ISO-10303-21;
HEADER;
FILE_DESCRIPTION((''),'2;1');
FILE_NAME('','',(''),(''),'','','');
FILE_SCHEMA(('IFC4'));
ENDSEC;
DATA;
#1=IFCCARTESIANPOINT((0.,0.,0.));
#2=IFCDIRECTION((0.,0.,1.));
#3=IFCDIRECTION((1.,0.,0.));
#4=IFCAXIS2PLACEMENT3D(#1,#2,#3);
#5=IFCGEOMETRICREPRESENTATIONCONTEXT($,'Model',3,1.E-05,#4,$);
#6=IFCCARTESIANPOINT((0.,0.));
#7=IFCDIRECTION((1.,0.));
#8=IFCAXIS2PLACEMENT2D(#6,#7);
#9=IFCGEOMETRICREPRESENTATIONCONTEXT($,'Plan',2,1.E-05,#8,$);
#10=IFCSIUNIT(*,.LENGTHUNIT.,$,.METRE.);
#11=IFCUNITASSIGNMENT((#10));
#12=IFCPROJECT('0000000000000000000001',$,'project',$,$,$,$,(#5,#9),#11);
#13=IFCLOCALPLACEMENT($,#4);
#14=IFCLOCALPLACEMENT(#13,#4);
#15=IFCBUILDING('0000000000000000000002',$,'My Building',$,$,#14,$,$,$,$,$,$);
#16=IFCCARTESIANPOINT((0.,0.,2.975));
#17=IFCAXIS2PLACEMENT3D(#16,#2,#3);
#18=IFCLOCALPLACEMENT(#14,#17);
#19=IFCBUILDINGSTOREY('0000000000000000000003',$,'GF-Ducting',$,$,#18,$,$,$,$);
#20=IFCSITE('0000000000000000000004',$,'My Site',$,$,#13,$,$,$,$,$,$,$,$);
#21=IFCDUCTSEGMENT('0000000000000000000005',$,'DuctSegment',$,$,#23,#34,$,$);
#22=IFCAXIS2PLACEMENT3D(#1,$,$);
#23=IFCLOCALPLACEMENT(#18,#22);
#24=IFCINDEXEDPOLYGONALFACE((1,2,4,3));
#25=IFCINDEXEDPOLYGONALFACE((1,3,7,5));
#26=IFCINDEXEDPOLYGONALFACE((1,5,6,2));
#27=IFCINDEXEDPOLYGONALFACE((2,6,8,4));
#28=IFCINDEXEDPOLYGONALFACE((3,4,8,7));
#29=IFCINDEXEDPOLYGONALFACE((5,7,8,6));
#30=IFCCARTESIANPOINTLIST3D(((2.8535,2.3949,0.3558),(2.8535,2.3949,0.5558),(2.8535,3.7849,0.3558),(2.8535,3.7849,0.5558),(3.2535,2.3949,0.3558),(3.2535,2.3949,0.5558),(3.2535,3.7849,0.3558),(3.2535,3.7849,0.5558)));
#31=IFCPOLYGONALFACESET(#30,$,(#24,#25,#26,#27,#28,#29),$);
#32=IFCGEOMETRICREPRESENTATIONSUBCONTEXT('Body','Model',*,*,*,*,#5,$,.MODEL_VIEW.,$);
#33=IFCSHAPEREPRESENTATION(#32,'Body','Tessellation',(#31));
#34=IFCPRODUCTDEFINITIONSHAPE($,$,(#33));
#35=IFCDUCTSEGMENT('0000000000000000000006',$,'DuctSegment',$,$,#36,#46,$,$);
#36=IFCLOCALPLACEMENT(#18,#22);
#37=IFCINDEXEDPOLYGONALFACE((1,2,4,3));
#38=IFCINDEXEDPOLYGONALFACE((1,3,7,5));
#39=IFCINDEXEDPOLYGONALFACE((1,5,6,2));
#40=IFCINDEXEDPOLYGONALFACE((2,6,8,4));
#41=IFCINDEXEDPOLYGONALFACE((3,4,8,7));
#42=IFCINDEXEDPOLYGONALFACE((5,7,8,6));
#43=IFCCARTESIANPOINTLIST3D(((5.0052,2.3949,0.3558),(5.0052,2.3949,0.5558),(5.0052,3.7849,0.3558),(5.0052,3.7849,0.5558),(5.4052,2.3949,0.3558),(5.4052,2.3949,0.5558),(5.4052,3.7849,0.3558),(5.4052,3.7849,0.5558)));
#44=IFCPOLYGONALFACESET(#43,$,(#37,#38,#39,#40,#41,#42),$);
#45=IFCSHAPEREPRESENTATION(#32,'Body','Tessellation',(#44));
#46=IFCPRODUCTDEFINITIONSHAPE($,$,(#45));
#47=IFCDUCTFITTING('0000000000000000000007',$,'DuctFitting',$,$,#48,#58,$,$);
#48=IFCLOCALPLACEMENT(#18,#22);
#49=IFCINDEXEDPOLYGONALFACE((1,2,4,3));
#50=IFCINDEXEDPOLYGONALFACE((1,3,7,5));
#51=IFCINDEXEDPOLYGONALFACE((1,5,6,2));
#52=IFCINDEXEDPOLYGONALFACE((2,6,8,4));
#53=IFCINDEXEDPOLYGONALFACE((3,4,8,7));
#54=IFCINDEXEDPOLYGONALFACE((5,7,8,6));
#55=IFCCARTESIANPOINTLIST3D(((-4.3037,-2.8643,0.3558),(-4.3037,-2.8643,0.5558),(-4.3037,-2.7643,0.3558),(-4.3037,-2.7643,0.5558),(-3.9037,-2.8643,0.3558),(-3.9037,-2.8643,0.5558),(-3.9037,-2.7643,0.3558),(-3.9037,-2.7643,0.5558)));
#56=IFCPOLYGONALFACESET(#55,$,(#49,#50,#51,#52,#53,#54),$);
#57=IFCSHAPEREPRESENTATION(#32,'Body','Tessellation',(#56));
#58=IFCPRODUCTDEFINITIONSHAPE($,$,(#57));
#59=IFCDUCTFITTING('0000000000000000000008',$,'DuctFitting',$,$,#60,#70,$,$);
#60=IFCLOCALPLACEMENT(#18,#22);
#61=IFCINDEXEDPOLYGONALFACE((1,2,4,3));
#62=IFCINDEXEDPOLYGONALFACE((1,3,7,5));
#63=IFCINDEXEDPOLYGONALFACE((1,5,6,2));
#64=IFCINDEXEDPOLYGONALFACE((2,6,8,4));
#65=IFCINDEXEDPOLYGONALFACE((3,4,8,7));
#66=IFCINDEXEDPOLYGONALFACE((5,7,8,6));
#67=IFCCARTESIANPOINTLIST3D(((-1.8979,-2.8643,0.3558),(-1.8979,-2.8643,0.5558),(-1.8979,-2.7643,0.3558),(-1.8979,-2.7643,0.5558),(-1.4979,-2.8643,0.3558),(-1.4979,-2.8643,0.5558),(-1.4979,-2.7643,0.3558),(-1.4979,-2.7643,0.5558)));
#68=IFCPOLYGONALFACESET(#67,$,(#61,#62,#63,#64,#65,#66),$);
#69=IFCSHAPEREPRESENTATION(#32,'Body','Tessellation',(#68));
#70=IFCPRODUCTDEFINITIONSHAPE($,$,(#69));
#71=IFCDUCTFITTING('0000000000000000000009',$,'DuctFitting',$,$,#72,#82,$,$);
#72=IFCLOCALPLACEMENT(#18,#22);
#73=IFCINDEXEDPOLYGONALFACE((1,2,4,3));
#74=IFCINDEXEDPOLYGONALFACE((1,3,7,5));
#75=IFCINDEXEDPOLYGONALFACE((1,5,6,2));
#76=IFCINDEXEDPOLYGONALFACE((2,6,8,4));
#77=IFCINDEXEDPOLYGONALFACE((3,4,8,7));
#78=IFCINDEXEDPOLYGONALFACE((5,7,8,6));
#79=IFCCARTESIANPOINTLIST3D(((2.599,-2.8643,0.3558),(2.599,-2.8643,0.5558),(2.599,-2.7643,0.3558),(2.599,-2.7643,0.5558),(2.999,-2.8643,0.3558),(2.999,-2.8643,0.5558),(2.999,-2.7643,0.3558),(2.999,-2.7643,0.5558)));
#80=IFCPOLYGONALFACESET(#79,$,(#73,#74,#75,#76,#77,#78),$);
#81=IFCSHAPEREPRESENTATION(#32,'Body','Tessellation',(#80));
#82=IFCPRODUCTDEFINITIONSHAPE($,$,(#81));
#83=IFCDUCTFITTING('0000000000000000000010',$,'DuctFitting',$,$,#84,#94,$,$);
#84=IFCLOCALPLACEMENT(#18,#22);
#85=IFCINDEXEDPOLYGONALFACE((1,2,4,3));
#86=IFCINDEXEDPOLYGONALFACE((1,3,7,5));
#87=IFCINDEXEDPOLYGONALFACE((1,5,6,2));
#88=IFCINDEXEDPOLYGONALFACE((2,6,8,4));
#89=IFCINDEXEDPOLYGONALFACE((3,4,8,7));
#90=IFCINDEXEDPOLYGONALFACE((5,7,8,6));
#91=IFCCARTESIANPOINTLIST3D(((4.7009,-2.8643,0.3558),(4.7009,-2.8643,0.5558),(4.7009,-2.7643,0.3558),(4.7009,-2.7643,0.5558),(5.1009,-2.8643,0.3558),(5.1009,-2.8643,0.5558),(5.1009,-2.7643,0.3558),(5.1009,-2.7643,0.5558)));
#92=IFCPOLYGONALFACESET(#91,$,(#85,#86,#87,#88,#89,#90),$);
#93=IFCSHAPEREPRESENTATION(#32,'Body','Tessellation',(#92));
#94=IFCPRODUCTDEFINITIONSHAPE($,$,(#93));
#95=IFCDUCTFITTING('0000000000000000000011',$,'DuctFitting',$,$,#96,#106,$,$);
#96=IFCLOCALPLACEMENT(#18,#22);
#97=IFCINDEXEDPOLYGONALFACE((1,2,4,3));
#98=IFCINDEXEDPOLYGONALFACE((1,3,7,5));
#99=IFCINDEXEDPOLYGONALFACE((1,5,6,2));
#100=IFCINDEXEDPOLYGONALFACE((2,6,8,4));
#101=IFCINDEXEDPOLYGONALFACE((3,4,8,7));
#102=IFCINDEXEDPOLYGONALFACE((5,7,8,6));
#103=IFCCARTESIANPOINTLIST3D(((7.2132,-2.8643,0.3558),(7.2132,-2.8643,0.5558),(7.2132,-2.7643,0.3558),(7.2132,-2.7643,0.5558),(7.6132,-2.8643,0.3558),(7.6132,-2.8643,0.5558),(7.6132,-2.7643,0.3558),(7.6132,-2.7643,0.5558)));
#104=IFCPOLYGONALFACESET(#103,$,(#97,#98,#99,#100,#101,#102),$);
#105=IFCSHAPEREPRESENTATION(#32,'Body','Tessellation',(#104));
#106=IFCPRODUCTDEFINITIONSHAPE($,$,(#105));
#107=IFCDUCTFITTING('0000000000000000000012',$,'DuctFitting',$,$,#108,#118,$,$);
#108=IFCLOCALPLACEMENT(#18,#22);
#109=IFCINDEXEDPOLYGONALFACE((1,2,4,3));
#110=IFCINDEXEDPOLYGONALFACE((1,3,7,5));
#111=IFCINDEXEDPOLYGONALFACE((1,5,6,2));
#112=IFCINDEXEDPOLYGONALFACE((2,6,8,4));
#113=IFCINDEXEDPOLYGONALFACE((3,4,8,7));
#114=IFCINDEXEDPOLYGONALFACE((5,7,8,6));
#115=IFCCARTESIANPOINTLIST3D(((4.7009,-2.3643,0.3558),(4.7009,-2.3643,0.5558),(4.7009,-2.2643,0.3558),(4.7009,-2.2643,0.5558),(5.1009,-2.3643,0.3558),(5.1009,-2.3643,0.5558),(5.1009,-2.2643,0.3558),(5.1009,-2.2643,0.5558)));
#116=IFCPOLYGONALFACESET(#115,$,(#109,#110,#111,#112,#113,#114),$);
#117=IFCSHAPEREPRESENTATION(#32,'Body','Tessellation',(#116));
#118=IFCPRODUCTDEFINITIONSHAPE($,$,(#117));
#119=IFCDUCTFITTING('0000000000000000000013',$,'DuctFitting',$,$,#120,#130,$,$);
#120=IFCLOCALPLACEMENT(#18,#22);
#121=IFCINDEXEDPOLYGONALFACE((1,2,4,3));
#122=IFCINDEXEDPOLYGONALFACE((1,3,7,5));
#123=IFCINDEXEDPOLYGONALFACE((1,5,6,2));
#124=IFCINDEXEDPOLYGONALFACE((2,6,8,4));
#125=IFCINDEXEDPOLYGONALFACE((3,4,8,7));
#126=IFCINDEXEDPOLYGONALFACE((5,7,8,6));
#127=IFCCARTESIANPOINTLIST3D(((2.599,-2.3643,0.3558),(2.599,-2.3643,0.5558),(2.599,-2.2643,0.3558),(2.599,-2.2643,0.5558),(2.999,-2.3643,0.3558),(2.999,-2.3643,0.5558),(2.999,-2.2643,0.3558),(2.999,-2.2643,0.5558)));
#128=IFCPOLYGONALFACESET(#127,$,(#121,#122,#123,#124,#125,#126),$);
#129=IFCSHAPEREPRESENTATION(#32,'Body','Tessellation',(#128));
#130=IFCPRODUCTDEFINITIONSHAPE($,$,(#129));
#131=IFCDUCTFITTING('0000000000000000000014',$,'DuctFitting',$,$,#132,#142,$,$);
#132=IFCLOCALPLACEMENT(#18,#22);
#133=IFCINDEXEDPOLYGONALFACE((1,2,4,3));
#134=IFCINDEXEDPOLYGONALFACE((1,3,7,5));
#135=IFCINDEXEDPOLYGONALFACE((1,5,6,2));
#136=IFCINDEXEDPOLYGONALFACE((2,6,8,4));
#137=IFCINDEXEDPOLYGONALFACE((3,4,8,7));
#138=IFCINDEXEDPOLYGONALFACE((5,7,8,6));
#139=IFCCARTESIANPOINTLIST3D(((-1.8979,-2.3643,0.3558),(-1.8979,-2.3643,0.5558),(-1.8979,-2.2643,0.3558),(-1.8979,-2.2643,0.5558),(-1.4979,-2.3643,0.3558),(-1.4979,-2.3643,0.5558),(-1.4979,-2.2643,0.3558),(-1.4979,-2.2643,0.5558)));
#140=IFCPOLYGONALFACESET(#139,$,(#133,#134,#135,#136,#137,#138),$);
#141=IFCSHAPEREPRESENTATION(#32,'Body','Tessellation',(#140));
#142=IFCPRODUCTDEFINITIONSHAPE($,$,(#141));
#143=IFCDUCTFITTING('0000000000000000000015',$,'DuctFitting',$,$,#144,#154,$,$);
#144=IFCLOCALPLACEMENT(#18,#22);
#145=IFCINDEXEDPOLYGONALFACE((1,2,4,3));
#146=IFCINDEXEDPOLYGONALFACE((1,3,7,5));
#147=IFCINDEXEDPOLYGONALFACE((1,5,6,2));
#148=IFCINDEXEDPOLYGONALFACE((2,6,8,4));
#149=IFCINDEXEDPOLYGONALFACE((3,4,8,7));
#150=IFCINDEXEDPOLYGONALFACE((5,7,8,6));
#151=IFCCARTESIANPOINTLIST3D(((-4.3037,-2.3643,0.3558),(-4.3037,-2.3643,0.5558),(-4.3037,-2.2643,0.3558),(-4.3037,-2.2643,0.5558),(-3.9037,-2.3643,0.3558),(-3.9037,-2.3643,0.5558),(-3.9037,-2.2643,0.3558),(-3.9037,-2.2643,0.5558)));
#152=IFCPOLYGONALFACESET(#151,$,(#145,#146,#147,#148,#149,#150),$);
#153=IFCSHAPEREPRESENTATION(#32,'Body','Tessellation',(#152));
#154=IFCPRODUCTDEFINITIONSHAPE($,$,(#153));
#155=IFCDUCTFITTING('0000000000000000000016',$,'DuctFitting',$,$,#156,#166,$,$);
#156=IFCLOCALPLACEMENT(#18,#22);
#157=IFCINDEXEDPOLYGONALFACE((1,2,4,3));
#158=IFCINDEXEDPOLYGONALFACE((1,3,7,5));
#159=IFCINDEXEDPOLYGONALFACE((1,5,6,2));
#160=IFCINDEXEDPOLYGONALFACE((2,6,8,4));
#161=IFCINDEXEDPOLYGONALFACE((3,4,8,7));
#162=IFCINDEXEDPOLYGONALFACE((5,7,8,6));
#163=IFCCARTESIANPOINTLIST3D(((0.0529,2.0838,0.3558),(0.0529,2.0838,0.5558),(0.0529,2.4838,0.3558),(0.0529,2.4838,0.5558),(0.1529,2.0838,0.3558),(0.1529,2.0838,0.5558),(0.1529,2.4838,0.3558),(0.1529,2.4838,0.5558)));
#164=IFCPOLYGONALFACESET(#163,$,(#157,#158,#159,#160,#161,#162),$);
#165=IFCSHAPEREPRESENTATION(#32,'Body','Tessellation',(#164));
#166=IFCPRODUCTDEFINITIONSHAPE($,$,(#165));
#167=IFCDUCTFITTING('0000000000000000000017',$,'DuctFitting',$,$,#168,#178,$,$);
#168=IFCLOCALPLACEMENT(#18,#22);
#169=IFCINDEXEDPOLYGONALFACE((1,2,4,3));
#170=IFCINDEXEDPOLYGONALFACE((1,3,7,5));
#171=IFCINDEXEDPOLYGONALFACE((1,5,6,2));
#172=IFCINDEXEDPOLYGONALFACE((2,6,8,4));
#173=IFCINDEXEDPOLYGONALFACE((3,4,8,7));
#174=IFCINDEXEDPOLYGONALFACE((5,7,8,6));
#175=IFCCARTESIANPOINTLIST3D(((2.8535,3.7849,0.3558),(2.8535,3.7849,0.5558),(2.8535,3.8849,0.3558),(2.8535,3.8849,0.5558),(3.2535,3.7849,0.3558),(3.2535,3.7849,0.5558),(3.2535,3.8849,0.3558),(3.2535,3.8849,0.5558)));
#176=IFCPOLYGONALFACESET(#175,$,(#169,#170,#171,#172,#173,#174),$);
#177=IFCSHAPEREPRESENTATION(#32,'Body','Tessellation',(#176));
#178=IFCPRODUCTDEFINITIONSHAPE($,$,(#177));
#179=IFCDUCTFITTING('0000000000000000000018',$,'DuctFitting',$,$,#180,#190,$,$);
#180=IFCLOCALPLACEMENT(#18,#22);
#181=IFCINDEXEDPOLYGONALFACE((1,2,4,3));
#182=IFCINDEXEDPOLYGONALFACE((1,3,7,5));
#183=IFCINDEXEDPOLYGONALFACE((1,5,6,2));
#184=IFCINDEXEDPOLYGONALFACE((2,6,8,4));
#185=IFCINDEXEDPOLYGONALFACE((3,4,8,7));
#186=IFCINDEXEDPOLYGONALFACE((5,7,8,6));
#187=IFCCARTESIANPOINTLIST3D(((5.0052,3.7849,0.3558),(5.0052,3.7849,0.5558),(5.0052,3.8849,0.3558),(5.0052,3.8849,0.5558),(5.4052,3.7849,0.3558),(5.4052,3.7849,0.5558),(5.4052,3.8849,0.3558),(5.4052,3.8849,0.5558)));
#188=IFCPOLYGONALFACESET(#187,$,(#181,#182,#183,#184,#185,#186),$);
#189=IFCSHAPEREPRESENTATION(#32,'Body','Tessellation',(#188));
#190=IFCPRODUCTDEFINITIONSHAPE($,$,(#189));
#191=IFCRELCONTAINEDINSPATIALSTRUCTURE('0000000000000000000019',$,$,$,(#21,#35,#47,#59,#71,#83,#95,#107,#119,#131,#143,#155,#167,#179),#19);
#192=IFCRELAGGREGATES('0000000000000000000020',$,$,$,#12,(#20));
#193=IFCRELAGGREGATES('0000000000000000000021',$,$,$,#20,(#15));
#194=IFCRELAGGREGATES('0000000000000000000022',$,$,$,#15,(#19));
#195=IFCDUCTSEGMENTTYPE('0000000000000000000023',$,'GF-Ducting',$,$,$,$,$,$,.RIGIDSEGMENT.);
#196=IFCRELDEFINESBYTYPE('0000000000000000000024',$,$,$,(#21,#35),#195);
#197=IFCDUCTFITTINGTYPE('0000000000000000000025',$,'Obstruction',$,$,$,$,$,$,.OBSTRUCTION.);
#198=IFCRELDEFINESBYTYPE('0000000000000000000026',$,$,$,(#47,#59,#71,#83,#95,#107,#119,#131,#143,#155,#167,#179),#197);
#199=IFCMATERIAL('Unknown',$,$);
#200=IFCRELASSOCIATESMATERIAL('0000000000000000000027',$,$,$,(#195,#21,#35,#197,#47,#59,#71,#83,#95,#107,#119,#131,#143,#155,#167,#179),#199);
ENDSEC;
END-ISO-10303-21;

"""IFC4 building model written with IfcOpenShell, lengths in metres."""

from ifc_helpers import new_model, si_unit, frame, origin_with_axes, origin_2d_with_axis, place, context, subcontext, project, spatial, rectangle, extrude, material, material_profile, profile_set, profile_usage, type_object, element, save


model = new_model("IFC4")

# Units and contexts
model_context = context("Model", 3, precision=1e-05, world=origin_with_axes())
plan_context = context("Plan", 2, precision=1e-05, world=origin_2d_with_axis())
body_context = subcontext(model_context, "Body", "Model", "MODEL_VIEW")
ifc_project = project(units=[si_unit("LENGTHUNIT", "METRE")], contexts=[model_context, plan_context])

# Site, building, storey
site_placement = place(None, origin_with_axes())
site = spatial("IfcSite", under=ifc_project, at=site_placement, Name="My Site")
building_placement = place(site_placement, origin_with_axes())
building = spatial("IfcBuilding", under=site, at=building_placement, Name="My Building")
storey_placement = place(building_placement, frame((0.0, 0.0, 2.975), z_axis=(0.0, 0.0, 1.0), x_axis=(1.0, 0.0, 0.0)))
storey = spatial("IfcBuildingStorey", under=building, at=storey_placement, Name="GF-Ducting")

# Duct segments
ifc_material = material(Name="Unknown")
ifc_material_profile_1 = material_profile(ifc_material, rectangle(XDim=0.4, YDim=0.2))
ifc_profile_set_1 = profile_set([ifc_material_profile_1])
duct_segment_type = type_object("IfcDuctSegmentType", Name="GF-Ducting", PredefinedType="RIGIDSEGMENT", material=ifc_profile_set_1)
ifc_profile_usage_1 = profile_usage(ifc_profile_set_1, cardinal=5)
duct_segment_1_placement = place(storey_placement, frame((3.0535, 3.7849, 0.4558), z_axis=(0.0, -1.0, 0.0), x_axis=(1.0, 0.0, 0.0)))
element("IfcDuctSegment", 1, at=duct_segment_1_placement, inside=storey, type_object=duct_segment_type, material=ifc_profile_usage_1, Name="DuctSegment", context=body_context, shape_type="SweptSolid", body=[
    extrude(rectangle(XDim=0.4, YDim=0.2), origin_with_axes(), (0.0, 0.0, 1.0), 1.39),
])
ifc_profile_usage_2 = profile_usage(ifc_profile_set_1, cardinal=5)
duct_segment_2_placement = place(storey_placement, frame((5.2052, 3.7849, 0.4558), z_axis=(0.0, -1.0, 0.0), x_axis=(1.0, 0.0, 0.0)))
element("IfcDuctSegment", 2, at=duct_segment_2_placement, inside=storey, type_object=duct_segment_type, material=ifc_profile_usage_2, Name="DuctSegment", context=body_context, shape_type="SweptSolid", body=[
    extrude(rectangle(XDim=0.4, YDim=0.2), origin_with_axes(), (0.0, 0.0, 1.0), 1.39),
])

# Duct fittings
ifc_material_profile_2 = material_profile(ifc_material, rectangle(XDim=0.4, YDim=0.2))
ifc_profile_set_2 = profile_set([ifc_material_profile_2])
ifc_profile_usage_3 = profile_usage(ifc_profile_set_2, cardinal=5)
duct_fitting_type = type_object("IfcDuctFittingType", Name="Obstruction", PredefinedType="OBSTRUCTION", material=ifc_profile_set_2)
duct_fitting_1_placement = place(storey_placement, frame((-4.1037, -2.8643, 0.4558), z_axis=(0.0, 1.0, 0.0), x_axis=(-1.0, 0.0, 0.0)))
element("IfcDuctFitting", 3, at=duct_fitting_1_placement, inside=storey, type_object=duct_fitting_type, material=ifc_profile_usage_3, Name="DuctFitting", context=body_context, shape_type="SweptSolid", body=[
    extrude(rectangle(XDim=0.4, YDim=0.2), origin_with_axes(), (0.0, 0.0, 1.0), 0.1),
])
ifc_profile_usage_4 = profile_usage(ifc_profile_set_2, cardinal=5)
duct_fitting_2_placement = place(storey_placement, frame((-1.6979, -2.8643, 0.4558), z_axis=(0.0, 1.0, 0.0), x_axis=(-1.0, 0.0, 0.0)))
element("IfcDuctFitting", 4, at=duct_fitting_2_placement, inside=storey, type_object=duct_fitting_type, material=ifc_profile_usage_4, Name="DuctFitting", context=body_context, shape_type="SweptSolid", body=[
    extrude(rectangle(XDim=0.4, YDim=0.2), origin_with_axes(), (0.0, 0.0, 1.0), 0.1),
])
ifc_profile_usage_5 = profile_usage(ifc_profile_set_2, cardinal=5)
duct_fitting_3_placement = place(storey_placement, frame((2.799, -2.8643, 0.4558), z_axis=(0.0, 1.0, 0.0), x_axis=(-1.0, 0.0, 0.0)))
element("IfcDuctFitting", 5, at=duct_fitting_3_placement, inside=storey, type_object=duct_fitting_type, material=ifc_profile_usage_5, Name="DuctFitting", context=body_context, shape_type="SweptSolid", body=[
    extrude(rectangle(XDim=0.4, YDim=0.2), origin_with_axes(), (0.0, 0.0, 1.0), 0.1),
])
ifc_profile_usage_6 = profile_usage(ifc_profile_set_2, cardinal=5)
duct_fitting_4_placement = place(storey_placement, frame((4.9009, -2.8643, 0.4558), z_axis=(0.0, 1.0, 0.0), x_axis=(-1.0, 0.0, 0.0)))
element("IfcDuctFitting", 6, at=duct_fitting_4_placement, inside=storey, type_object=duct_fitting_type, material=ifc_profile_usage_6, Name="DuctFitting", context=body_context, shape_type="SweptSolid", body=[
    extrude(rectangle(XDim=0.4, YDim=0.2), origin_with_axes(), (0.0, 0.0, 1.0), 0.1),
])
ifc_profile_usage_7 = profile_usage(ifc_profile_set_2, cardinal=5)
duct_fitting_5_placement = place(storey_placement, frame((7.4132, -2.8643, 0.4558), z_axis=(0.0, 1.0, 0.0), x_axis=(-1.0, 0.0, 0.0)))
element("IfcDuctFitting", 7, at=duct_fitting_5_placement, inside=storey, type_object=duct_fitting_type, material=ifc_profile_usage_7, Name="DuctFitting", context=body_context, shape_type="SweptSolid", body=[
    extrude(rectangle(XDim=0.4, YDim=0.2), origin_with_axes(), (0.0, 0.0, 1.0), 0.1),
])
ifc_profile_usage_8 = profile_usage(ifc_profile_set_2, cardinal=5)
duct_fitting_6_placement = place(storey_placement, frame((4.9009, -2.3643, 0.4558), z_axis=(0.0, 1.0, 0.0), x_axis=(-1.0, 0.0, 0.0)))
element("IfcDuctFitting", 8, at=duct_fitting_6_placement, inside=storey, type_object=duct_fitting_type, material=ifc_profile_usage_8, Name="DuctFitting", context=body_context, shape_type="SweptSolid", body=[
    extrude(rectangle(XDim=0.4, YDim=0.2), origin_with_axes(), (0.0, 0.0, 1.0), 0.1),
])
ifc_profile_usage_9 = profile_usage(ifc_profile_set_2, cardinal=5)
duct_fitting_7_placement = place(storey_placement, frame((2.799, -2.3643, 0.4558), z_axis=(0.0, 1.0, 0.0), x_axis=(-1.0, 0.0, 0.0)))
element("IfcDuctFitting", 9, at=duct_fitting_7_placement, inside=storey, type_object=duct_fitting_type, material=ifc_profile_usage_9, Name="DuctFitting", context=body_context, shape_type="SweptSolid", body=[
    extrude(rectangle(XDim=0.4, YDim=0.2), origin_with_axes(), (0.0, 0.0, 1.0), 0.1),
])
ifc_profile_usage_10 = profile_usage(ifc_profile_set_2, cardinal=5)
duct_fitting_8_placement = place(storey_placement, frame((-1.6979, -2.3643, 0.4558), z_axis=(0.0, 1.0, 0.0), x_axis=(-1.0, 0.0, 0.0)))
element("IfcDuctFitting", 10, at=duct_fitting_8_placement, inside=storey, type_object=duct_fitting_type, material=ifc_profile_usage_10, Name="DuctFitting", context=body_context, shape_type="SweptSolid", body=[
    extrude(rectangle(XDim=0.4, YDim=0.2), origin_with_axes(), (0.0, 0.0, 1.0), 0.1),
])
ifc_profile_usage_11 = profile_usage(ifc_profile_set_2, cardinal=5)
duct_fitting_9_placement = place(storey_placement, frame((-4.1037, -2.3643, 0.4558), z_axis=(0.0, 1.0, 0.0), x_axis=(-1.0, 0.0, 0.0)))
element("IfcDuctFitting", 11, at=duct_fitting_9_placement, inside=storey, type_object=duct_fitting_type, material=ifc_profile_usage_11, Name="DuctFitting", context=body_context, shape_type="SweptSolid", body=[
    extrude(rectangle(XDim=0.4, YDim=0.2), origin_with_axes(), (0.0, 0.0, 1.0), 0.1),
])
ifc_profile_usage_12 = profile_usage(ifc_profile_set_2, cardinal=5)
duct_fitting_10_placement = place(storey_placement, frame((0.0529, 2.2838, 0.4558), z_axis=(1.0, 0.0, 0.0), x_axis=(0.0, 1.0, 0.0)))
element("IfcDuctFitting", 12, at=duct_fitting_10_placement, inside=storey, type_object=duct_fitting_type, material=ifc_profile_usage_12, Name="DuctFitting", context=body_context, shape_type="SweptSolid", body=[
    extrude(rectangle(XDim=0.4, YDim=0.2), origin_with_axes(), (0.0, 0.0, 1.0), 0.1),
])
ifc_profile_usage_13 = profile_usage(ifc_profile_set_2, cardinal=5)
duct_fitting_11_placement = place(storey_placement, frame((3.0535, 3.8849, 0.4558), z_axis=(0.0, -1.0, 0.0), x_axis=(1.0, 0.0, 0.0)))
element("IfcDuctFitting", 13, at=duct_fitting_11_placement, inside=storey, type_object=duct_fitting_type, material=ifc_profile_usage_13, Name="DuctFitting", context=body_context, shape_type="SweptSolid", body=[
    extrude(rectangle(XDim=0.4, YDim=0.2), origin_with_axes(), (0.0, 0.0, 1.0), 0.1),
])
ifc_profile_usage_14 = profile_usage(ifc_profile_set_2, cardinal=5)
duct_fitting_12_placement = place(storey_placement, frame((5.2052, 3.8849, 0.4558), z_axis=(0.0, -1.0, 0.0), x_axis=(1.0, 0.0, 0.0)))
element("IfcDuctFitting", 14, at=duct_fitting_12_placement, inside=storey, type_object=duct_fitting_type, material=ifc_profile_usage_14, Name="DuctFitting", context=body_context, shape_type="SweptSolid", body=[
    extrude(rectangle(XDim=0.4, YDim=0.2), origin_with_axes(), (0.0, 0.0, 1.0), 0.1),
])

save(model, "model.ifc")
